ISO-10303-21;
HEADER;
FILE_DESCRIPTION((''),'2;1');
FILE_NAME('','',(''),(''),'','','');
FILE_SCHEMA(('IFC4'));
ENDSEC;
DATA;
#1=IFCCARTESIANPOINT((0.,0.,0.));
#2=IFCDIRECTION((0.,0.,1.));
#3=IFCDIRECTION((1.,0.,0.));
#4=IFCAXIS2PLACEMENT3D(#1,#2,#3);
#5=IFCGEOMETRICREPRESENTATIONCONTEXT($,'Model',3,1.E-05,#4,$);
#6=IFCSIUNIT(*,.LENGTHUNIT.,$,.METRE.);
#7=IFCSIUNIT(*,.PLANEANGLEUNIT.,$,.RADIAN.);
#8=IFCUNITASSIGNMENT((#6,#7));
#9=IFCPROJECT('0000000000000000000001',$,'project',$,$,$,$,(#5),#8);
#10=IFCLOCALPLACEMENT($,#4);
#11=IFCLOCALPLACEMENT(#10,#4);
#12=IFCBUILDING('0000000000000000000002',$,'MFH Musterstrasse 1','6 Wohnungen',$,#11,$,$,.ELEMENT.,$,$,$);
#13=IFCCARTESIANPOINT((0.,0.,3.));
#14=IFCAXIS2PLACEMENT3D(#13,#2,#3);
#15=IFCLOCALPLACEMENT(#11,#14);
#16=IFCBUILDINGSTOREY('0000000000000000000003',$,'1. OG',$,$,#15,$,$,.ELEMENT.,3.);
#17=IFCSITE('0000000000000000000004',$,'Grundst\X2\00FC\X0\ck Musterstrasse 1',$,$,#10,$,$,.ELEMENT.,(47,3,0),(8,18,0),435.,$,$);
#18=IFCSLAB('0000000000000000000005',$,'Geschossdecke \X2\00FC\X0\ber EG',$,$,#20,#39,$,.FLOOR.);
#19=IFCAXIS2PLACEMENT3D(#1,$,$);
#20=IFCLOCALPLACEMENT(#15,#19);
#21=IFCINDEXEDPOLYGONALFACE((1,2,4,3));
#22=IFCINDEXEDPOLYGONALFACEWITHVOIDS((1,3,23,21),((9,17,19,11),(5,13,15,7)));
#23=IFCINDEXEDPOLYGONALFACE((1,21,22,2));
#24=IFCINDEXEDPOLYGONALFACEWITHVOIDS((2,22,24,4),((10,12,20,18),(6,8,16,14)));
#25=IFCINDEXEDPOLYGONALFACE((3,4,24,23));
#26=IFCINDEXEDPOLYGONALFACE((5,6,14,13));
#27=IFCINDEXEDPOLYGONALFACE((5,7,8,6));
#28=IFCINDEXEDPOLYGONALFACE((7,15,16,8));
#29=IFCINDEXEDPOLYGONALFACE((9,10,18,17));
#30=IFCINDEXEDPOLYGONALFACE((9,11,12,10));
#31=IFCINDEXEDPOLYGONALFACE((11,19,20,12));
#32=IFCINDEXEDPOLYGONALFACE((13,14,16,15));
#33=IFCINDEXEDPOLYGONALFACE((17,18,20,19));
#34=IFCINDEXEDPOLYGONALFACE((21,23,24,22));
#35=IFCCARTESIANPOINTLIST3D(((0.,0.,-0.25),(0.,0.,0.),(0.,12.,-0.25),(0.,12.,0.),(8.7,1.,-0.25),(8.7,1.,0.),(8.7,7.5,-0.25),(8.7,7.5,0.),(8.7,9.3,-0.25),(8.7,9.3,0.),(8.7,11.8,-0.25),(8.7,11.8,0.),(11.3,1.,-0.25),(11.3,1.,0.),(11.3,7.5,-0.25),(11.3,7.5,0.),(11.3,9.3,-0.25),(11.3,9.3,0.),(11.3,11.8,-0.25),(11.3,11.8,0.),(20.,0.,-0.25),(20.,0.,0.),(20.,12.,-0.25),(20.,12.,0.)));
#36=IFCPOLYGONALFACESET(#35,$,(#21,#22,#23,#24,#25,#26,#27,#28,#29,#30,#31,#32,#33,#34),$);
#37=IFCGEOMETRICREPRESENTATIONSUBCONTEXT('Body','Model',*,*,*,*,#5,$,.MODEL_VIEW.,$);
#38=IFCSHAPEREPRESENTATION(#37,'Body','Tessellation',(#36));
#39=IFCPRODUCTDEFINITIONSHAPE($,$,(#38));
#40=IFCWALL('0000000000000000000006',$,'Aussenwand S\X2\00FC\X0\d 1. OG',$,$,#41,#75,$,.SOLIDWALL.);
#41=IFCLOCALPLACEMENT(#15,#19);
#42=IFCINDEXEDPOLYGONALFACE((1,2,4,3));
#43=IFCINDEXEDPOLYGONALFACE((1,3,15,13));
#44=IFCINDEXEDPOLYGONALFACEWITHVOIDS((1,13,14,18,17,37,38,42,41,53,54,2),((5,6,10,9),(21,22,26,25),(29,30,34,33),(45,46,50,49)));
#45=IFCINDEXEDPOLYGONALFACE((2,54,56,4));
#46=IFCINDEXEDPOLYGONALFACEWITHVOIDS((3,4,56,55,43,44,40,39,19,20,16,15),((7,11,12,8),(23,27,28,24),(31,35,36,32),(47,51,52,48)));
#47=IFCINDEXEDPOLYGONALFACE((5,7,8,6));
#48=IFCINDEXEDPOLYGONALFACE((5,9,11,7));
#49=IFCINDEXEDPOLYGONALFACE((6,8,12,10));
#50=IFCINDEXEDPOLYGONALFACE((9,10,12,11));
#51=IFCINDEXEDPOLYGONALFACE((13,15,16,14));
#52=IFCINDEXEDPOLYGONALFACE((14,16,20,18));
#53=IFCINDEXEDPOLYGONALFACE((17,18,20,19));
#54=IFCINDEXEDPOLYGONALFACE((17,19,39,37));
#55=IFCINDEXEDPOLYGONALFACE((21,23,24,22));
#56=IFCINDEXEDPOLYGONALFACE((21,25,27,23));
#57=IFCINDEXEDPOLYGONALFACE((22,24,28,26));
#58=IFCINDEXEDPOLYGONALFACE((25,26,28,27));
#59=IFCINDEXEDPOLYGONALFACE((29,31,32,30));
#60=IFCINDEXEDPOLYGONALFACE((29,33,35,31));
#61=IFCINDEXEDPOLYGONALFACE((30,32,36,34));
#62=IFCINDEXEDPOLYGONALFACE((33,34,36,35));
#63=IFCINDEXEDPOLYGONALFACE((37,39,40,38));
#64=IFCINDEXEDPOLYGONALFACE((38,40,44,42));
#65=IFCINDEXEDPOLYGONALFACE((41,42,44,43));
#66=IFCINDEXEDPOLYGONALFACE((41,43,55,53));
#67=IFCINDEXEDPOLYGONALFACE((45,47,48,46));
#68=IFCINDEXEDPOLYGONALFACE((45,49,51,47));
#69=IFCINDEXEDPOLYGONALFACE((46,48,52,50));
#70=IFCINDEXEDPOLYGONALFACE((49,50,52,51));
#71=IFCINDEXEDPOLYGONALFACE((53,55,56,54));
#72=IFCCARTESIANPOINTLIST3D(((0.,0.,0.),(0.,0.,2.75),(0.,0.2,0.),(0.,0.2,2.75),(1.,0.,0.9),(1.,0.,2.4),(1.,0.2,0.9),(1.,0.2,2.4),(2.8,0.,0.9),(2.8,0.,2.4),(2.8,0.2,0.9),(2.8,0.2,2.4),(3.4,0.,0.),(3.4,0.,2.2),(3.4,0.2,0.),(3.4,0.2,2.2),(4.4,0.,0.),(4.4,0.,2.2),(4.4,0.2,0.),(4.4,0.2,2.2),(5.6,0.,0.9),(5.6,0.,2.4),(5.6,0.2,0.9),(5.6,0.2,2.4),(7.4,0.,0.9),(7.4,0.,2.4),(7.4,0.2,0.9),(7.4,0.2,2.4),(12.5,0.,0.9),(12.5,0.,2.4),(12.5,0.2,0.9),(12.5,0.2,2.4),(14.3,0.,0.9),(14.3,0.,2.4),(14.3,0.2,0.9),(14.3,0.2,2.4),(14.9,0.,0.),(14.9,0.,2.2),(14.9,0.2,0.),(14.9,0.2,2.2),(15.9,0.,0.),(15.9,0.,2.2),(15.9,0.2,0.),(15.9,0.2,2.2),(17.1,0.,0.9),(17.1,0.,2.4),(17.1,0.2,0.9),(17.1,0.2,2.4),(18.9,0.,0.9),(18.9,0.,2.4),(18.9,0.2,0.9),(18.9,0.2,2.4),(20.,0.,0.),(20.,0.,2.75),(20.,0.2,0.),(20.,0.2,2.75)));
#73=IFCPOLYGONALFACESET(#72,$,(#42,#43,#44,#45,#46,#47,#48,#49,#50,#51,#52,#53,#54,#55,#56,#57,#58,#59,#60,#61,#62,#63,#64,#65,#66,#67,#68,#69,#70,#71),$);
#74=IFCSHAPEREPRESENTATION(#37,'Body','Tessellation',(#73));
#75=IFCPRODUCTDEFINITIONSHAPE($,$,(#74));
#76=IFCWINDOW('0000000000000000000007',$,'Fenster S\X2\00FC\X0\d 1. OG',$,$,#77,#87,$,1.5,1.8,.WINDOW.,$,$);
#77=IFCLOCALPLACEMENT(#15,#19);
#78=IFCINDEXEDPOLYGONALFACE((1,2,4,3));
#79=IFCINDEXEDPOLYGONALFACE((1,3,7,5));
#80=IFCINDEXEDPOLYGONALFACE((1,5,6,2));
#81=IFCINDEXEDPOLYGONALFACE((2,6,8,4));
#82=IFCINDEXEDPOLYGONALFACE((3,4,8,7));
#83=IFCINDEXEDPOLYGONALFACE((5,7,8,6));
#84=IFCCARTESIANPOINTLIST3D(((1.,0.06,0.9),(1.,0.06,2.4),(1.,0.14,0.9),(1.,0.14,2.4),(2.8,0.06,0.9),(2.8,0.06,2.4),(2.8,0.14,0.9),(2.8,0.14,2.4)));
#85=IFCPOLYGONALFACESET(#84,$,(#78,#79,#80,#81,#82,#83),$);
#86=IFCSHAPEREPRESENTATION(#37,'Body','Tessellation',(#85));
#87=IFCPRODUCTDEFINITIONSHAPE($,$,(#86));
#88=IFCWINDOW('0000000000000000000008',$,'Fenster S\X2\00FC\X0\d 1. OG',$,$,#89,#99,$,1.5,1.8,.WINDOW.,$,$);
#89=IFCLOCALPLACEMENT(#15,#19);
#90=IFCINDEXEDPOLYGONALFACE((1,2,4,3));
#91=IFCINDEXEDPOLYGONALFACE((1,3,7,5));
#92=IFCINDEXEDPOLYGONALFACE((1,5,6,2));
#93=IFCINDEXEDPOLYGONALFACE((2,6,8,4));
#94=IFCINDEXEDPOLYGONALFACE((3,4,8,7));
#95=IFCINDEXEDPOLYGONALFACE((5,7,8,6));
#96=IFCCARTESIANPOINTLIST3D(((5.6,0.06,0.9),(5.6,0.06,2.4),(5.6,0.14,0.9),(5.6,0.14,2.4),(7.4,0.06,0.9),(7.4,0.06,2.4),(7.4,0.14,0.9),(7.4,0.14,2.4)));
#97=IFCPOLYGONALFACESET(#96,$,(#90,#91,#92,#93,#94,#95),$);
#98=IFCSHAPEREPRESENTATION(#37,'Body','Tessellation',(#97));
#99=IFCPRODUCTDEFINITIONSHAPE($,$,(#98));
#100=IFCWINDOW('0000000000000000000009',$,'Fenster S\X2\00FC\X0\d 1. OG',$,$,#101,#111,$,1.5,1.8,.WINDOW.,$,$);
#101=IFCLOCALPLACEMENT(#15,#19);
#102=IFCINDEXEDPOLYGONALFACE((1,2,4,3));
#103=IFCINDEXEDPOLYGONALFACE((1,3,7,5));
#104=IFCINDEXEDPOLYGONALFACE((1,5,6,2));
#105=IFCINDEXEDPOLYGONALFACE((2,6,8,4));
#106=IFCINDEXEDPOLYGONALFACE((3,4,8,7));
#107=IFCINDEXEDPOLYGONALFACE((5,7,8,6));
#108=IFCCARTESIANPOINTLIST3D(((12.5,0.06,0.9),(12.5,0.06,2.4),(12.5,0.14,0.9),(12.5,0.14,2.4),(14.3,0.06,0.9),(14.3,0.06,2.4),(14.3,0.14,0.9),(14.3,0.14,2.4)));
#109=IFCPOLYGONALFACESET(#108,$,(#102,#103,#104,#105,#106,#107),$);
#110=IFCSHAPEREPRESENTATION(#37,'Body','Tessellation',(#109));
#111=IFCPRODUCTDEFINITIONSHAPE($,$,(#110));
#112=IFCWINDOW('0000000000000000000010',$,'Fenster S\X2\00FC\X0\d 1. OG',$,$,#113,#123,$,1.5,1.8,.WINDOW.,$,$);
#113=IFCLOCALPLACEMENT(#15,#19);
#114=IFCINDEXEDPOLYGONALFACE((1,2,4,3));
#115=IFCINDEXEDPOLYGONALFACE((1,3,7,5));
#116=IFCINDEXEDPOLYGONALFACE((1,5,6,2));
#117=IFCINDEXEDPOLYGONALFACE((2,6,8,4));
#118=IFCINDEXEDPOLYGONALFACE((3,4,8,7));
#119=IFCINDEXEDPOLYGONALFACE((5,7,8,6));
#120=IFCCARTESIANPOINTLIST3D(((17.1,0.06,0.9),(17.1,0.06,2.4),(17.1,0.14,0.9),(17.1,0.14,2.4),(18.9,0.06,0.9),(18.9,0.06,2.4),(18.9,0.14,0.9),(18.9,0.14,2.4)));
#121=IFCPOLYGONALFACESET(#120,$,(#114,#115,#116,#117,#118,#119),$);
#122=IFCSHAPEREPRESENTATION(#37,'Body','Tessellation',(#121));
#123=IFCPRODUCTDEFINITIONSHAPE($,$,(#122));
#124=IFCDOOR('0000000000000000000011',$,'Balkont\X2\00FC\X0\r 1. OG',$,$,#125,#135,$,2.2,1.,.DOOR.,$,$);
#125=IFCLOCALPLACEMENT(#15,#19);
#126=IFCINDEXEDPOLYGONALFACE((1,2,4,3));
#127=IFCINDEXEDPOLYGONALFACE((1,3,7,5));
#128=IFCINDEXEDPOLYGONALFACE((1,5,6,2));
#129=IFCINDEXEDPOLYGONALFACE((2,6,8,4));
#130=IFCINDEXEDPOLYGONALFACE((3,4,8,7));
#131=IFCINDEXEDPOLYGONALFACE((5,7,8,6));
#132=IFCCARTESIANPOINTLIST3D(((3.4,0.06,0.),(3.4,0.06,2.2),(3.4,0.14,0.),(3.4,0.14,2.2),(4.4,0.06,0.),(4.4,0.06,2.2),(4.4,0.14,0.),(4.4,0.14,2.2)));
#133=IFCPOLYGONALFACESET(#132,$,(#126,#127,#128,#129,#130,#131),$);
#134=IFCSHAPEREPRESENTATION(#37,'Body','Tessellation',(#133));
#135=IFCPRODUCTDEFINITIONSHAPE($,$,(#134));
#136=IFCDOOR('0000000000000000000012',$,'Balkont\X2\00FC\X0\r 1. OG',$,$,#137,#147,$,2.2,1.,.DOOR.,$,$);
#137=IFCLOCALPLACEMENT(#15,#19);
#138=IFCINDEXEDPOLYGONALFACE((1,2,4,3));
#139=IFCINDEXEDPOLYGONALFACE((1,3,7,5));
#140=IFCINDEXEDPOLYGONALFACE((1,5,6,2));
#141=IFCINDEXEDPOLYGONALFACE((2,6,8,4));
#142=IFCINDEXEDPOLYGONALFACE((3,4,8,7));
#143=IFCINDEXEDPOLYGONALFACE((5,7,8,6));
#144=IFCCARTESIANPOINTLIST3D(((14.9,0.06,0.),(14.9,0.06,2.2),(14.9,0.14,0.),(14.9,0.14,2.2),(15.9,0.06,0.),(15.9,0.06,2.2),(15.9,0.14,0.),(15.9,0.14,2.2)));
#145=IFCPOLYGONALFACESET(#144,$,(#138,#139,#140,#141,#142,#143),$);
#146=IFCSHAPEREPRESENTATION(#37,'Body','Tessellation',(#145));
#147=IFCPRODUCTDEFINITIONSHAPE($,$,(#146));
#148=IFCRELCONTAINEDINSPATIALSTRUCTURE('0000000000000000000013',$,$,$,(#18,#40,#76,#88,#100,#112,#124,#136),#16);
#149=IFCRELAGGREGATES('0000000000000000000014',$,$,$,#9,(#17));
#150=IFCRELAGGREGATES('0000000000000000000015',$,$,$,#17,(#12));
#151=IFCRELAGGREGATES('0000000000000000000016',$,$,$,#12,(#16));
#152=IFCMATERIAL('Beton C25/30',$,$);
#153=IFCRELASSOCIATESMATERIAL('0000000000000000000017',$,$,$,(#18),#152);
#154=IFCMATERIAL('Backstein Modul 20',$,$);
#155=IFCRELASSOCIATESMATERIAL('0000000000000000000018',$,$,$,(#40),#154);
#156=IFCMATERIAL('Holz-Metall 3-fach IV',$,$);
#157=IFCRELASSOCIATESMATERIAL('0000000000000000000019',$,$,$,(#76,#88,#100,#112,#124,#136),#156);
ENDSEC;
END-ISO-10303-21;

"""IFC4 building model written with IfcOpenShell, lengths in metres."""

from ifc_helpers import new_model, si_unit, frame, frame_2d, origin_with_axes, place, context, subcontext, project, spatial, rectangle, extrude, material, element, fill, save


model = new_model("IFC4")

# Units and contexts
model_context = context("Model", 3, precision=1e-05, world=origin_with_axes())
body_context = subcontext(model_context, "Body", "Model", "MODEL_VIEW")
ifc_project = project(units=[si_unit("LENGTHUNIT", "METRE"), si_unit("PLANEANGLEUNIT", "RADIAN")], contexts=[model_context])

# Site, building, storey
site_placement = place(None, origin_with_axes())
site = spatial("IfcSite", under=ifc_project, at=site_placement, Name="Grundstück Musterstrasse 1", CompositionType="ELEMENT", RefLatitude=(47, 3, 0), RefLongitude=(8, 18, 0), RefElevation=435.0)
building_placement = place(site_placement, origin_with_axes())
building = spatial("IfcBuilding", under=site, at=building_placement, Name="MFH Musterstrasse 1", Description="6 Wohnungen", CompositionType="ELEMENT")
storey_placement = place(building_placement, frame((0.0, 0.0, 3.0), z_axis=(0.0, 0.0, 1.0), x_axis=(1.0, 0.0, 0.0)))
storey = spatial("IfcBuildingStorey", under=building, at=storey_placement, Name="1. OG", CompositionType="ELEMENT", Elevation=3.0)

# Slab, openings
ifc_material_1 = material(Name="Beton C25/30")
slab_placement = place(storey_placement, origin_with_axes())
slab = element("IfcSlab", 1, at=slab_placement, inside=storey, material=ifc_material_1, Name="Geschossdecke über EG", PredefinedType="FLOOR", context=body_context, shape_type="SweptSolid", body=[
    extrude(rectangle(XDim=20.0, YDim=12.0, at=frame_2d((10.0, 6.0), x_axis=(1.0, 0.0))), frame((0.0, 0.0, -0.25), z_axis=(0.0, 0.0, 1.0), x_axis=(1.0, 0.0, 0.0)), (0.0, 0.0, 1.0), 0.25),
])
opening_1_placement = place(storey_placement, origin_with_axes())
element("IfcOpeningElement", 2, at=opening_1_placement, cuts=slab, PredefinedType="OPENING", context=body_context, shape_type="SweptSolid", body=[
    extrude(rectangle(XDim=2.6, YDim=6.5, at=frame_2d((1.3, 3.25), x_axis=(1.0, 0.0))), frame((8.7, 1.0, -0.26), z_axis=(0.0, 0.0, 1.0), x_axis=(1.0, 0.0, 0.0)), (0.0, 0.0, 1.0), 0.27),
])
opening_2_placement = place(storey_placement, origin_with_axes())
element("IfcOpeningElement", 3, at=opening_2_placement, cuts=slab, PredefinedType="OPENING", context=body_context, shape_type="SweptSolid", body=[
    extrude(rectangle(XDim=2.6, YDim=2.5, at=frame_2d((1.3, 1.25), x_axis=(1.0, 0.0))), frame((8.7, 9.3, -0.26), z_axis=(0.0, 0.0, 1.0), x_axis=(1.0, 0.0, 0.0)), (0.0, 0.0, 1.0), 0.27),
])

# Wall, openings, windows, doors
ifc_material_2 = material(Name="Backstein Modul 20")
wall_1_placement = place(storey_placement, origin_with_axes())
wall_1 = element("IfcWall", 4, at=wall_1_placement, inside=storey, material=ifc_material_2, Name="Aussenwand Süd 1. OG", PredefinedType="SOLIDWALL", context=body_context, shape_type="SweptSolid", body=[
    extrude(rectangle(XDim=20.0, YDim=0.2, at=frame_2d((10.0, 0.1), x_axis=(1.0, 0.0))), origin_with_axes(), (0.0, 0.0, 1.0), 2.75),
])
opening_3_placement = place(storey_placement, origin_with_axes())
element("IfcOpeningElement", 5, at=opening_3_placement, cuts=wall_1, PredefinedType="OPENING", context=body_context, shape_type="SweptSolid", body=[
    extrude(rectangle(XDim=1.8, YDim=0.3, at=frame_2d((0.9, 0.15), x_axis=(1.0, 0.0))), frame((1.0, -0.05, 0.9), z_axis=(0.0, 0.0, 1.0), x_axis=(1.0, 0.0, 0.0)), (0.0, 0.0, 1.0), 1.5),
])
opening_4_placement = place(storey_placement, origin_with_axes())
element("IfcOpeningElement", 6, at=opening_4_placement, cuts=wall_1, PredefinedType="OPENING", context=body_context, shape_type="SweptSolid", body=[
    extrude(rectangle(XDim=1.8, YDim=0.3, at=frame_2d((0.9, 0.15), x_axis=(1.0, 0.0))), frame((5.6, -0.05, 0.9), z_axis=(0.0, 0.0, 1.0), x_axis=(1.0, 0.0, 0.0)), (0.0, 0.0, 1.0), 1.5),
])
opening_5_placement = place(storey_placement, origin_with_axes())
element("IfcOpeningElement", 7, at=opening_5_placement, cuts=wall_1, PredefinedType="OPENING", context=body_context, shape_type="SweptSolid", body=[
    extrude(rectangle(XDim=1.8, YDim=0.3, at=frame_2d((0.9, 0.15), x_axis=(1.0, 0.0))), frame((12.5, -0.05, 0.9), z_axis=(0.0, 0.0, 1.0), x_axis=(1.0, 0.0, 0.0)), (0.0, 0.0, 1.0), 1.5),
])
opening_6_placement = place(storey_placement, origin_with_axes())
element("IfcOpeningElement", 8, at=opening_6_placement, cuts=wall_1, PredefinedType="OPENING", context=body_context, shape_type="SweptSolid", body=[
    extrude(rectangle(XDim=1.8, YDim=0.3, at=frame_2d((0.9, 0.15), x_axis=(1.0, 0.0))), frame((17.1, -0.05, 0.9), z_axis=(0.0, 0.0, 1.0), x_axis=(1.0, 0.0, 0.0)), (0.0, 0.0, 1.0), 1.5),
])
opening_7_placement = place(storey_placement, origin_with_axes())
element("IfcOpeningElement", 9, at=opening_7_placement, cuts=wall_1, PredefinedType="OPENING", context=body_context, shape_type="SweptSolid", body=[
    extrude(rectangle(XDim=1.0, YDim=0.3, at=frame_2d((0.5, 0.15), x_axis=(1.0, 0.0))), frame((3.4, -0.05, 0.0), z_axis=(0.0, 0.0, 1.0), x_axis=(1.0, 0.0, 0.0)), (0.0, 0.0, 1.0), 2.2),
])
opening_8_placement = place(storey_placement, origin_with_axes())
element("IfcOpeningElement", 10, at=opening_8_placement, cuts=wall_1, PredefinedType="OPENING", context=body_context, shape_type="SweptSolid", body=[
    extrude(rectangle(XDim=1.0, YDim=0.3, at=frame_2d((0.5, 0.15), x_axis=(1.0, 0.0))), frame((14.9, -0.05, 0.0), z_axis=(0.0, 0.0, 1.0), x_axis=(1.0, 0.0, 0.0)), (0.0, 0.0, 1.0), 2.2),
])
opening_9_placement = place(storey_placement, origin_with_axes())
opening_9 = element("IfcOpeningElement", 11, at=opening_9_placement, cuts=wall_1, PredefinedType="OPENING", context=body_context, shape_type="SweptSolid", body=[
    extrude(rectangle(XDim=1.8, YDim=0.22, at=frame_2d((0.9, 0.11), x_axis=(1.0, 0.0))), frame((1.0, -0.01, 0.9), z_axis=(0.0, 0.0, 1.0), x_axis=(1.0, 0.0, 0.0)), (0.0, 0.0, 1.0), 1.5),
])
opening_10_placement = place(storey_placement, origin_with_axes())
opening_10 = element("IfcOpeningElement", 12, at=opening_10_placement, cuts=wall_1, PredefinedType="OPENING", context=body_context, shape_type="SweptSolid", body=[
    extrude(rectangle(XDim=1.8, YDim=0.22, at=frame_2d((0.9, 0.11), x_axis=(1.0, 0.0))), frame((5.6, -0.01, 0.9), z_axis=(0.0, 0.0, 1.0), x_axis=(1.0, 0.0, 0.0)), (0.0, 0.0, 1.0), 1.5),
])
opening_11_placement = place(storey_placement, origin_with_axes())
opening_11 = element("IfcOpeningElement", 13, at=opening_11_placement, cuts=wall_1, PredefinedType="OPENING", context=body_context, shape_type="SweptSolid", body=[
    extrude(rectangle(XDim=1.8, YDim=0.22, at=frame_2d((0.9, 0.11), x_axis=(1.0, 0.0))), frame((12.5, -0.01, 0.9), z_axis=(0.0, 0.0, 1.0), x_axis=(1.0, 0.0, 0.0)), (0.0, 0.0, 1.0), 1.5),
])
opening_12_placement = place(storey_placement, origin_with_axes())
opening_12 = element("IfcOpeningElement", 14, at=opening_12_placement, cuts=wall_1, PredefinedType="OPENING", context=body_context, shape_type="SweptSolid", body=[
    extrude(rectangle(XDim=1.8, YDim=0.22, at=frame_2d((0.9, 0.11), x_axis=(1.0, 0.0))), frame((17.1, -0.01, 0.9), z_axis=(0.0, 0.0, 1.0), x_axis=(1.0, 0.0, 0.0)), (0.0, 0.0, 1.0), 1.5),
])
opening_13_placement = place(storey_placement, origin_with_axes())
opening_13 = element("IfcOpeningElement", 15, at=opening_13_placement, cuts=wall_1, PredefinedType="OPENING", context=body_context, shape_type="SweptSolid", body=[
    extrude(rectangle(XDim=1.0, YDim=0.22, at=frame_2d((0.5, 0.11), x_axis=(1.0, 0.0))), frame((3.4, -0.01, 0.0), z_axis=(0.0, 0.0, 1.0), x_axis=(1.0, 0.0, 0.0)), (0.0, 0.0, 1.0), 2.2),
])
opening_14_placement = place(storey_placement, origin_with_axes())
opening_14 = element("IfcOpeningElement", 16, at=opening_14_placement, cuts=wall_1, PredefinedType="OPENING", context=body_context, shape_type="SweptSolid", body=[
    extrude(rectangle(XDim=1.0, YDim=0.22, at=frame_2d((0.5, 0.11), x_axis=(1.0, 0.0))), frame((14.9, -0.01, 0.0), z_axis=(0.0, 0.0, 1.0), x_axis=(1.0, 0.0, 0.0)), (0.0, 0.0, 1.0), 2.2),
])
ifc_material_3 = material(Name="Holz-Metall 3-fach IV")
window_1_placement = place(storey_placement, origin_with_axes())
window_1 = element("IfcWindow", 17, at=window_1_placement, inside=storey, material=ifc_material_3, Name="Fenster Süd 1. OG", OverallHeight=1.5, OverallWidth=1.8, PredefinedType="WINDOW", context=body_context, shape_type="SweptSolid", body=[
    extrude(rectangle(XDim=1.8, YDim=0.08, at=frame_2d((0.9, 0.04), x_axis=(1.0, 0.0))), frame((1.0, 0.06, 0.9), z_axis=(0.0, 0.0, 1.0), x_axis=(1.0, 0.0, 0.0)), (0.0, 0.0, 1.0), 1.5),
])
fill(opening_9, window_1)
window_2_placement = place(storey_placement, origin_with_axes())
window_2 = element("IfcWindow", 18, at=window_2_placement, inside=storey, material=ifc_material_3, Name="Fenster Süd 1. OG", OverallHeight=1.5, OverallWidth=1.8, PredefinedType="WINDOW", context=body_context, shape_type="SweptSolid", body=[
    extrude(rectangle(XDim=1.8, YDim=0.08, at=frame_2d((0.9, 0.04), x_axis=(1.0, 0.0))), frame((5.6, 0.06, 0.9), z_axis=(0.0, 0.0, 1.0), x_axis=(1.0, 0.0, 0.0)), (0.0, 0.0, 1.0), 1.5),
])
fill(opening_10, window_2)
window_3_placement = place(storey_placement, origin_with_axes())
window_3 = element("IfcWindow", 19, at=window_3_placement, inside=storey, material=ifc_material_3, Name="Fenster Süd 1. OG", OverallHeight=1.5, OverallWidth=1.8, PredefinedType="WINDOW", context=body_context, shape_type="SweptSolid", body=[
    extrude(rectangle(XDim=1.8, YDim=0.08, at=frame_2d((0.9, 0.04), x_axis=(1.0, 0.0))), frame((12.5, 0.06, 0.9), z_axis=(0.0, 0.0, 1.0), x_axis=(1.0, 0.0, 0.0)), (0.0, 0.0, 1.0), 1.5),
])
fill(opening_11, window_3)
window_4_placement = place(storey_placement, origin_with_axes())
window_4 = element("IfcWindow", 20, at=window_4_placement, inside=storey, material=ifc_material_3, Name="Fenster Süd 1. OG", OverallHeight=1.5, OverallWidth=1.8, PredefinedType="WINDOW", context=body_context, shape_type="SweptSolid", body=[
    extrude(rectangle(XDim=1.8, YDim=0.08, at=frame_2d((0.9, 0.04), x_axis=(1.0, 0.0))), frame((17.1, 0.06, 0.9), z_axis=(0.0, 0.0, 1.0), x_axis=(1.0, 0.0, 0.0)), (0.0, 0.0, 1.0), 1.5),
])
fill(opening_12, window_4)
door_1_placement = place(storey_placement, origin_with_axes())
door_1 = element("IfcDoor", 21, at=door_1_placement, inside=storey, material=ifc_material_3, Name="Balkontür 1. OG", OverallHeight=2.2, OverallWidth=1.0, PredefinedType="DOOR", context=body_context, shape_type="SweptSolid", body=[
    extrude(rectangle(XDim=1.0, YDim=0.08, at=frame_2d((0.5, 0.04), x_axis=(1.0, 0.0))), frame((3.4, 0.06, 0.0), z_axis=(0.0, 0.0, 1.0), x_axis=(1.0, 0.0, 0.0)), (0.0, 0.0, 1.0), 2.2),
])
fill(opening_13, door_1)
door_2_placement = place(storey_placement, origin_with_axes())
door_2 = element("IfcDoor", 22, at=door_2_placement, inside=storey, material=ifc_material_3, Name="Balkontür 1. OG", OverallHeight=2.2, OverallWidth=1.0, PredefinedType="DOOR", context=body_context, shape_type="SweptSolid", body=[
    extrude(rectangle(XDim=1.0, YDim=0.08, at=frame_2d((0.5, 0.04), x_axis=(1.0, 0.0))), frame((14.9, 0.06, 0.0), z_axis=(0.0, 0.0, 1.0), x_axis=(1.0, 0.0, 0.0)), (0.0, 0.0, 1.0), 2.2),
])
fill(opening_14, door_2)

save(model, "model.ifc")
